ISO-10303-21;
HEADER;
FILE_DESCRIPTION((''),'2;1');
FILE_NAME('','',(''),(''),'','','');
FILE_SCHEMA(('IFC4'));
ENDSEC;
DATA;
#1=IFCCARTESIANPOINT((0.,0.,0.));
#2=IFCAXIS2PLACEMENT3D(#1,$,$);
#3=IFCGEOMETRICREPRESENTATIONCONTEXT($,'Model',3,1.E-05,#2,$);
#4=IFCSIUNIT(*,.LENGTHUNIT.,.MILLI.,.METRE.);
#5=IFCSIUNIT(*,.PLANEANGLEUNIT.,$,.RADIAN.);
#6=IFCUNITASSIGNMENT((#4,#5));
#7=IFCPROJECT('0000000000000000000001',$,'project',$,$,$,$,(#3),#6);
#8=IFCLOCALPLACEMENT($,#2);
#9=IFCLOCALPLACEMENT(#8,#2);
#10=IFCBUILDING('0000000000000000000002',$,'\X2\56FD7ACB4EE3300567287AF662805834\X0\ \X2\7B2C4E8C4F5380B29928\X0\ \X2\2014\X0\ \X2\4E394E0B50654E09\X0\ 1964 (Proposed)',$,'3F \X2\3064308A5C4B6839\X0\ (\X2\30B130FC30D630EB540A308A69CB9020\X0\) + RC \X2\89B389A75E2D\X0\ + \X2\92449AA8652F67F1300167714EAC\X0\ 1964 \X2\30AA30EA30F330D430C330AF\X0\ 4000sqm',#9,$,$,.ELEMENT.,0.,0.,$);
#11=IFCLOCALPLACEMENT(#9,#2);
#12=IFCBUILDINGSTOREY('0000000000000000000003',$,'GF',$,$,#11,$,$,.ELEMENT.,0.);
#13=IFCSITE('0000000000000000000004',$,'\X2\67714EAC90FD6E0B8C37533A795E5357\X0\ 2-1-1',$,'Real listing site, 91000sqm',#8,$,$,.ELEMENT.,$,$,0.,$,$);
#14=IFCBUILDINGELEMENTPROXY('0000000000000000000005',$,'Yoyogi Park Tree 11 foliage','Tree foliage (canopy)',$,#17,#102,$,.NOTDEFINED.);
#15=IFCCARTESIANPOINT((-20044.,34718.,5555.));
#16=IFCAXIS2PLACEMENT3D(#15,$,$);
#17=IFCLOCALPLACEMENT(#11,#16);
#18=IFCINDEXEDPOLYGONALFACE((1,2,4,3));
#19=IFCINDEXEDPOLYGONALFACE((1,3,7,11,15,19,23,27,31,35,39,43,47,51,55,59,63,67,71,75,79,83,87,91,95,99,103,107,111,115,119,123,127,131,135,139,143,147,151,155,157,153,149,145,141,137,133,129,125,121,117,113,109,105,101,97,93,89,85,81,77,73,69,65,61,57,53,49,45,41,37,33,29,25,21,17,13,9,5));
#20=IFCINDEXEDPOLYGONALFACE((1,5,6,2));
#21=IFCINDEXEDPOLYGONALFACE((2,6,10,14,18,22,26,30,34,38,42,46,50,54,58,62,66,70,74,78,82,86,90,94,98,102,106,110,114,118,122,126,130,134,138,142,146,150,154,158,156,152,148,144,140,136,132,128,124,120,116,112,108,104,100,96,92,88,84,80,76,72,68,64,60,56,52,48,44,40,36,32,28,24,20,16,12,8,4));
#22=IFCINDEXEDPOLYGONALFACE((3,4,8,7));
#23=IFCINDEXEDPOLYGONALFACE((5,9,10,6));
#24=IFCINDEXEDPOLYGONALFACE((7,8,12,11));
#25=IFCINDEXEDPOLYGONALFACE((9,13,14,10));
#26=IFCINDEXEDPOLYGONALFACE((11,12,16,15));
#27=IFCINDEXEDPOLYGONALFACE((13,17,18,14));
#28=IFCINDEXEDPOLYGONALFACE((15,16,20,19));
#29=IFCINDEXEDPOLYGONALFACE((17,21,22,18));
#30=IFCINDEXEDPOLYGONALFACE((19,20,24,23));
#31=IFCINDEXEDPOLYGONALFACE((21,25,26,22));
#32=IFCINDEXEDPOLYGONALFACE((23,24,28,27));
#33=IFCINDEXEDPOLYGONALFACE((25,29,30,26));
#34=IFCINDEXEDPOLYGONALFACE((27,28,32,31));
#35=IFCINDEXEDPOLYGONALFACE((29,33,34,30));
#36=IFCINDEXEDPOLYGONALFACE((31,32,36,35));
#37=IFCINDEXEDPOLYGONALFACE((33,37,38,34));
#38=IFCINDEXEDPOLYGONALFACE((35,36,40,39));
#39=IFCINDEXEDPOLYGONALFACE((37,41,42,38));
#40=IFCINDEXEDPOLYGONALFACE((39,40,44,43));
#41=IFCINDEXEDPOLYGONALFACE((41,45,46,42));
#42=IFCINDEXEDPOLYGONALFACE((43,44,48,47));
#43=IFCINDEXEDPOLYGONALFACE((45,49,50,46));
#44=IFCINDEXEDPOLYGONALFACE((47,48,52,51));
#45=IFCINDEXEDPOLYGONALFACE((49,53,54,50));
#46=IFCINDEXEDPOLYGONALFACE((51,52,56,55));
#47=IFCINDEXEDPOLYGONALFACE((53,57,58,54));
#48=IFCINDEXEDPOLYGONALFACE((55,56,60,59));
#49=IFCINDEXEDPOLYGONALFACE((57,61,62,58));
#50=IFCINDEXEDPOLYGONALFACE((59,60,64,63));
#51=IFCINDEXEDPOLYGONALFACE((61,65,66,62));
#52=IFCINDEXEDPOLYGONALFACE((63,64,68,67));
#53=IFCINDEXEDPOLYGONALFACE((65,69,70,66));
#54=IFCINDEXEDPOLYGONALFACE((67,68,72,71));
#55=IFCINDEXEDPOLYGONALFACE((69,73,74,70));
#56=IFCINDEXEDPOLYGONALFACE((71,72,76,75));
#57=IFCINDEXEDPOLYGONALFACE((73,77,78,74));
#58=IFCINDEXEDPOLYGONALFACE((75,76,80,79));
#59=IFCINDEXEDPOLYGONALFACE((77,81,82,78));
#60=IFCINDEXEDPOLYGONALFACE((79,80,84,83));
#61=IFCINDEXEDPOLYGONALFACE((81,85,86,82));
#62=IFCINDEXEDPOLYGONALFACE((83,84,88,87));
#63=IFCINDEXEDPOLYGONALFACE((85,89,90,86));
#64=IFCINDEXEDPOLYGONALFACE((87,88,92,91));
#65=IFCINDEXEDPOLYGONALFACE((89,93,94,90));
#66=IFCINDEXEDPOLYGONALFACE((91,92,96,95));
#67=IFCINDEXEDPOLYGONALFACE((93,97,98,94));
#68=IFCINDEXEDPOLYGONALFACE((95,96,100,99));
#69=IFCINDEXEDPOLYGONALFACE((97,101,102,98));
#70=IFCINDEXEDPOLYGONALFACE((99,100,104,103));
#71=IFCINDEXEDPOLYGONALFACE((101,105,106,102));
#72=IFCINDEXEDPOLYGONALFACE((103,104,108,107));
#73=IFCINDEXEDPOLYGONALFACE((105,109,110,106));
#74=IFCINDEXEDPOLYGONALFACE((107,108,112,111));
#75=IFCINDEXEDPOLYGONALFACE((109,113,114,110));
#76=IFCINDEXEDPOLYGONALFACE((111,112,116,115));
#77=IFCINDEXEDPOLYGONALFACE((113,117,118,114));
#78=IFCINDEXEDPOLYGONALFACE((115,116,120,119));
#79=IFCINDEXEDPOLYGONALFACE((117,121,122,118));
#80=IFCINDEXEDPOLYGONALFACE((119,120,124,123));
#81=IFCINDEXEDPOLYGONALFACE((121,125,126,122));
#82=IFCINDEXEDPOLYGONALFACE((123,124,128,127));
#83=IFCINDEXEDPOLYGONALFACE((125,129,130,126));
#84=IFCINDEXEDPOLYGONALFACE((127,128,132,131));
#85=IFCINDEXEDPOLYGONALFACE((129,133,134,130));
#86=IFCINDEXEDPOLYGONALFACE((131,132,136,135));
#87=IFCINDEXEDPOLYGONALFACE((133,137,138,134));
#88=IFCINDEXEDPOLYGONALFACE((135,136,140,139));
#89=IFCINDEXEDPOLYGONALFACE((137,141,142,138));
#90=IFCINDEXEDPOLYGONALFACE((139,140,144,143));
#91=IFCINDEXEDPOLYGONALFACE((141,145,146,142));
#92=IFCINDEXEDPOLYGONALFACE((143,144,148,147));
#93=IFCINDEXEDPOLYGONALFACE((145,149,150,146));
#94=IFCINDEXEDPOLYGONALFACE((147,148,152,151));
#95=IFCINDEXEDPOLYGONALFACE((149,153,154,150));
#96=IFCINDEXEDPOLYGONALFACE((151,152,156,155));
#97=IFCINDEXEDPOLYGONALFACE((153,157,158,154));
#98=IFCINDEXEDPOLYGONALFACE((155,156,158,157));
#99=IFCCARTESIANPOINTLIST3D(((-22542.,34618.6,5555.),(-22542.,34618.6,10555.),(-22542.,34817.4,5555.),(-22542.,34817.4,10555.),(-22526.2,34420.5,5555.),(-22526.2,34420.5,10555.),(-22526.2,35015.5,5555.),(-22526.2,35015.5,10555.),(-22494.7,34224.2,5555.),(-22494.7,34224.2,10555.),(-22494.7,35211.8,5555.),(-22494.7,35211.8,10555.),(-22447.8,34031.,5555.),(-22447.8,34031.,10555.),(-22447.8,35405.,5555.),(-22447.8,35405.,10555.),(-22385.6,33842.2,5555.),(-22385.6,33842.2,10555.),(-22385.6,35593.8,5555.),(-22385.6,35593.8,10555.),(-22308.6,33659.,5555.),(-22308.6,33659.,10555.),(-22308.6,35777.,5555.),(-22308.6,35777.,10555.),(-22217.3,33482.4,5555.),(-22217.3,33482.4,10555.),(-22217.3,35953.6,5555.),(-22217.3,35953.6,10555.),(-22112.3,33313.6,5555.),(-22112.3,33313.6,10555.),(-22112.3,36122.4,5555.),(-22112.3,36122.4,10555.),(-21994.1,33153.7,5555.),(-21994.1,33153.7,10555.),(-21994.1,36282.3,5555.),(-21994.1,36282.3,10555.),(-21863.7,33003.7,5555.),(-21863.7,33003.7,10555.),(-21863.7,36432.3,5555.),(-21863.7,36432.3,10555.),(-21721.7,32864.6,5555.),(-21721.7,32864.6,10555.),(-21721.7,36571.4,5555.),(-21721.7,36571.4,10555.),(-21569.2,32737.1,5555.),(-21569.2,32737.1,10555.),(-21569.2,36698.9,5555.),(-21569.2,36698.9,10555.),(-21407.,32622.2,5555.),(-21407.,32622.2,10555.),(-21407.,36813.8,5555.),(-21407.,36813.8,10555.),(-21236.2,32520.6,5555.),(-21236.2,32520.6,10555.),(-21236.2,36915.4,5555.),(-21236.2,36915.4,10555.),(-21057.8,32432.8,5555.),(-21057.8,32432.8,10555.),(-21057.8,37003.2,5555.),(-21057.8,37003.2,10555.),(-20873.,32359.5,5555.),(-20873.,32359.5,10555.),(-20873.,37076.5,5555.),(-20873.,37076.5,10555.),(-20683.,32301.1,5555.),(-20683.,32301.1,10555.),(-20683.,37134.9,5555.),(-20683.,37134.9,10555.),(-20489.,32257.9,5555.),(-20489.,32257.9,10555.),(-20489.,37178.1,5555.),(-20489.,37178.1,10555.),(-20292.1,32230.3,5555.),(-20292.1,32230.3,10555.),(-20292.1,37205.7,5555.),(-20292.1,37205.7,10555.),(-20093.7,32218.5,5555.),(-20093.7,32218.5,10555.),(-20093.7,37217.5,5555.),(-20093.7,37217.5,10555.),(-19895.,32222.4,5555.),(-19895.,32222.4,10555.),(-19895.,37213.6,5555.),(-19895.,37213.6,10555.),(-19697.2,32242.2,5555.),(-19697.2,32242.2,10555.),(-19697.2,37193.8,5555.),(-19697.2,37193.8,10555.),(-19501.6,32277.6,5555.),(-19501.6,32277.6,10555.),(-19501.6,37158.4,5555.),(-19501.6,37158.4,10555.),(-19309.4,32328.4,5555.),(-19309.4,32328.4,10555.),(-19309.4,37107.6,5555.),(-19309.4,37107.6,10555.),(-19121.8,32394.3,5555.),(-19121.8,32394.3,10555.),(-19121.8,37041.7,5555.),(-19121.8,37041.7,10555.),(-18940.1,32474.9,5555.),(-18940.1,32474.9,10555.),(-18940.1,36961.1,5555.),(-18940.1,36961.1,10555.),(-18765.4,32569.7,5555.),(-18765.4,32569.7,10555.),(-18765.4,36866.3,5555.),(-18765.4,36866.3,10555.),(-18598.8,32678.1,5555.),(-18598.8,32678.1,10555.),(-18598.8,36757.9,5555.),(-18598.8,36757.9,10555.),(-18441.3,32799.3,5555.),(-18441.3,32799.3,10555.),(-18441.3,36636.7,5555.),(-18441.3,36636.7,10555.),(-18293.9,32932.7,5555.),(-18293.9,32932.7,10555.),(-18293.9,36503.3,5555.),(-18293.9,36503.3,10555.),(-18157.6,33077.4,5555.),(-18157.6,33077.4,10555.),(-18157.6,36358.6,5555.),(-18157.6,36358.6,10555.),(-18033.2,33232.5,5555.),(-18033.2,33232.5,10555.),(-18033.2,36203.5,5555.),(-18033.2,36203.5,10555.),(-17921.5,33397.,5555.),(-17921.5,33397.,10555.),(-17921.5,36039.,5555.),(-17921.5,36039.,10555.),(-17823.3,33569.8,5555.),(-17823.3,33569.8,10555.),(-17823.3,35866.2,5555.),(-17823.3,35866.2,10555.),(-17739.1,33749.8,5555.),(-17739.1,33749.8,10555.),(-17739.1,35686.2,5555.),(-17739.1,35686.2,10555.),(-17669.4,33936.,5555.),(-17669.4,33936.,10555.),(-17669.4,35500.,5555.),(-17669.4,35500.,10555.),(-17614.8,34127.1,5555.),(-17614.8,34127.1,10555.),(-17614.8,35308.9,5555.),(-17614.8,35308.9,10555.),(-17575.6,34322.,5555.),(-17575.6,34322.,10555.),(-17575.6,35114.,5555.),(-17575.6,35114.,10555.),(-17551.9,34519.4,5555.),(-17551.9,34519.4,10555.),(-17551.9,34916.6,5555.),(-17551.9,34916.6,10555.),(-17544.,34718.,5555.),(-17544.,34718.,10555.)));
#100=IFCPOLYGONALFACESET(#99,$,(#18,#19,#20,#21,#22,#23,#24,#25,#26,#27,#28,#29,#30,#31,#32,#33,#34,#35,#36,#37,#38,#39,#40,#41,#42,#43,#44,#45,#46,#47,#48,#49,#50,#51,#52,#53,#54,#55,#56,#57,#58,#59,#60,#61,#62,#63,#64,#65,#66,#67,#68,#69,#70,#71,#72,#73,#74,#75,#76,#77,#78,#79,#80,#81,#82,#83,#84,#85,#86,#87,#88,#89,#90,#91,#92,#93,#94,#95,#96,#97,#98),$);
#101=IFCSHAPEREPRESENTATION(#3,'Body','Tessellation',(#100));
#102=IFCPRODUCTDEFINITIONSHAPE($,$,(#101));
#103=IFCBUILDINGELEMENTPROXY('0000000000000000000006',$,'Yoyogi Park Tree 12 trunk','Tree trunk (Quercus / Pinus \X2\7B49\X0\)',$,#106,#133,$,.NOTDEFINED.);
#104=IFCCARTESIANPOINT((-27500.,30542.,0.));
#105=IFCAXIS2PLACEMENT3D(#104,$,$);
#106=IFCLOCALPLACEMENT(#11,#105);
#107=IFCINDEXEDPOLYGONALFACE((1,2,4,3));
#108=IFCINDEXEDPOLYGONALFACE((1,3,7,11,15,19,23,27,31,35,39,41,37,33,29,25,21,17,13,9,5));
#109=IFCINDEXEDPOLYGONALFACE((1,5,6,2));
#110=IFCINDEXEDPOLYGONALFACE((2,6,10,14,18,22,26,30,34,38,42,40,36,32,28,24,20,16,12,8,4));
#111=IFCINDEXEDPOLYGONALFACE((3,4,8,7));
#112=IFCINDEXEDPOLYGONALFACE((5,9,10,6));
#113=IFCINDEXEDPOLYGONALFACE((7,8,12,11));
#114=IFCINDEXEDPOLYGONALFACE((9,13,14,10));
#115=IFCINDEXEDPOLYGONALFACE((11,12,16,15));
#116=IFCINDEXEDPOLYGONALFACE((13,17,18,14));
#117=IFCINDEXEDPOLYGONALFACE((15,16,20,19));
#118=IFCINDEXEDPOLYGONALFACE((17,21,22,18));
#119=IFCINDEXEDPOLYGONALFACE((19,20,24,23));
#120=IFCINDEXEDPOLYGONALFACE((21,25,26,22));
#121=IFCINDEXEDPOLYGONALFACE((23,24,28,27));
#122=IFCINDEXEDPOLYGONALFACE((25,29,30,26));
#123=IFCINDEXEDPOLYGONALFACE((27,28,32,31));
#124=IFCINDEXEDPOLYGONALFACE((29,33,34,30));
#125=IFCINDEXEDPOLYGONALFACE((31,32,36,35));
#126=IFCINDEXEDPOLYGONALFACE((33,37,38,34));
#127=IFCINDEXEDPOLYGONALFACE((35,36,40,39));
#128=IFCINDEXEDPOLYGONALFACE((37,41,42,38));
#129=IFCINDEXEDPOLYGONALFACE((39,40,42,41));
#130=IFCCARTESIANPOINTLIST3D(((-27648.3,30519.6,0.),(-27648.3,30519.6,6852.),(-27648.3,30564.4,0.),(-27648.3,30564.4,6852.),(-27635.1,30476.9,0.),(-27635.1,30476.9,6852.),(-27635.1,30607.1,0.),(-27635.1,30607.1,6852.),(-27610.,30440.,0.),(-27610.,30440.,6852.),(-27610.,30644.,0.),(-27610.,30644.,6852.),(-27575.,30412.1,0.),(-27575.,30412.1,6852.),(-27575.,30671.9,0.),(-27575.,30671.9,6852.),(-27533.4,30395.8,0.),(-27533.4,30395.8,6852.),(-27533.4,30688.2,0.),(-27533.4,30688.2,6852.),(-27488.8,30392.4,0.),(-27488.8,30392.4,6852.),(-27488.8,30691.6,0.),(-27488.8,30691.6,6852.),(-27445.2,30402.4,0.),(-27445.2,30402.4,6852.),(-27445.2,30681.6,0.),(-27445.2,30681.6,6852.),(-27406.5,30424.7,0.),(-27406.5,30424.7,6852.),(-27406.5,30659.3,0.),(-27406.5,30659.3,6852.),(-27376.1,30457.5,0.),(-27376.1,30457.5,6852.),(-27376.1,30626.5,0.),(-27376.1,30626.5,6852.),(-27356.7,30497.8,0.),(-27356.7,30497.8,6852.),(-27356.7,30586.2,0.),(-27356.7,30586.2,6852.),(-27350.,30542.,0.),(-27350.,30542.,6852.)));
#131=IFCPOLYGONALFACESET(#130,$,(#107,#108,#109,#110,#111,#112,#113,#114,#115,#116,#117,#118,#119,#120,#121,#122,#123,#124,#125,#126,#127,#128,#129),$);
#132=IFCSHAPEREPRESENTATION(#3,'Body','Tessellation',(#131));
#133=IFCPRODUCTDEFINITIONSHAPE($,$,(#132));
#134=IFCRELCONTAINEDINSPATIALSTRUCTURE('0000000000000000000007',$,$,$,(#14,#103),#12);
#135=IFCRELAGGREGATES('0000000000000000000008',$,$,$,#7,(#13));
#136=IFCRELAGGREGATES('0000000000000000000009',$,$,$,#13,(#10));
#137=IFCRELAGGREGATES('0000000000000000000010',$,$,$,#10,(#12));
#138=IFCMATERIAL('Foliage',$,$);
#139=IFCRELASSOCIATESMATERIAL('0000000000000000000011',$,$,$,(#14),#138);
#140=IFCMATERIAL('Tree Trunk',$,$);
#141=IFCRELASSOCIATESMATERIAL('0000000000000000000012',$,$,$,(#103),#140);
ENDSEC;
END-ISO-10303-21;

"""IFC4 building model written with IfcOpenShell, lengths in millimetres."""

from ifc_helpers import new_model, si_unit, frame, origin, origin_2d, place, context, project, spatial, circle, extrude, material, element, save


model = new_model("IFC4")

# Units and contexts
model_context = context("Model", 3, precision=1e-05, world=origin())
ifc_project = project(units=[si_unit("LENGTHUNIT", "METRE", prefix="MILLI"), si_unit("PLANEANGLEUNIT", "RADIAN")], contexts=[model_context])

# Site, building, storey
site_placement = place(None, origin())
site = spatial("IfcSite", under=ifc_project, at=site_placement, Name="東京都渋谷区神南 2-1-1", ObjectType="Real listing site, 91000sqm", CompositionType="ELEMENT", RefElevation=0.0)
building_placement = place(site_placement, origin())
building = spatial("IfcBuilding", under=site, at=building_placement, Name="国立代々木競技場 第二体育館 — 丹下健三 1964 (Proposed)", ObjectType="3F つり屋根 (ケーブル吊り構造) + RC 観覧席 + 鉄骨支柱、東京 1964 オリンピック 4000sqm", CompositionType="ELEMENT", ElevationOfRefHeight=0.0, ElevationOfTerrain=0.0)
storey_placement = place(building_placement, origin())
storey = spatial("IfcBuildingStorey", under=building, at=storey_placement, Name="GF", CompositionType="ELEMENT", Elevation=0.0)

# Building element proxies
ifc_material_1 = material(Name="Tree Trunk")
ifc_material_2 = material(Name="Foliage")
proxy_1_placement = place(storey_placement, frame((-20044.0, 34718.0, 5555.0)))
element("IfcBuildingElementProxy", 1, at=proxy_1_placement, inside=storey, material=ifc_material_2, Name="Yoyogi Park Tree 11 foliage", Description="Tree foliage (canopy)", PredefinedType="NOTDEFINED", context=model_context, shape_type="SweptSolid", body=[
    extrude(circle(Radius=2500.0, at=origin_2d()), frame((-20044.0, 34718.0, 5555.0)), (0.0, 0.0, 1.0), 5000.0),
])
proxy_2_placement = place(storey_placement, frame((-27500.0, 30542.0, 0.0)))
element("IfcBuildingElementProxy", 2, at=proxy_2_placement, inside=storey, material=ifc_material_1, Name="Yoyogi Park Tree 12 trunk", Description="Tree trunk (Quercus / Pinus 等)", PredefinedType="NOTDEFINED", context=model_context, shape_type="SweptSolid", body=[
    extrude(circle(Radius=150.0, at=origin_2d()), frame((-27500.0, 30542.0, 0.0)), (0.0, 0.0, 1.0), 6852.0),
])

save(model, "model.ifc")
